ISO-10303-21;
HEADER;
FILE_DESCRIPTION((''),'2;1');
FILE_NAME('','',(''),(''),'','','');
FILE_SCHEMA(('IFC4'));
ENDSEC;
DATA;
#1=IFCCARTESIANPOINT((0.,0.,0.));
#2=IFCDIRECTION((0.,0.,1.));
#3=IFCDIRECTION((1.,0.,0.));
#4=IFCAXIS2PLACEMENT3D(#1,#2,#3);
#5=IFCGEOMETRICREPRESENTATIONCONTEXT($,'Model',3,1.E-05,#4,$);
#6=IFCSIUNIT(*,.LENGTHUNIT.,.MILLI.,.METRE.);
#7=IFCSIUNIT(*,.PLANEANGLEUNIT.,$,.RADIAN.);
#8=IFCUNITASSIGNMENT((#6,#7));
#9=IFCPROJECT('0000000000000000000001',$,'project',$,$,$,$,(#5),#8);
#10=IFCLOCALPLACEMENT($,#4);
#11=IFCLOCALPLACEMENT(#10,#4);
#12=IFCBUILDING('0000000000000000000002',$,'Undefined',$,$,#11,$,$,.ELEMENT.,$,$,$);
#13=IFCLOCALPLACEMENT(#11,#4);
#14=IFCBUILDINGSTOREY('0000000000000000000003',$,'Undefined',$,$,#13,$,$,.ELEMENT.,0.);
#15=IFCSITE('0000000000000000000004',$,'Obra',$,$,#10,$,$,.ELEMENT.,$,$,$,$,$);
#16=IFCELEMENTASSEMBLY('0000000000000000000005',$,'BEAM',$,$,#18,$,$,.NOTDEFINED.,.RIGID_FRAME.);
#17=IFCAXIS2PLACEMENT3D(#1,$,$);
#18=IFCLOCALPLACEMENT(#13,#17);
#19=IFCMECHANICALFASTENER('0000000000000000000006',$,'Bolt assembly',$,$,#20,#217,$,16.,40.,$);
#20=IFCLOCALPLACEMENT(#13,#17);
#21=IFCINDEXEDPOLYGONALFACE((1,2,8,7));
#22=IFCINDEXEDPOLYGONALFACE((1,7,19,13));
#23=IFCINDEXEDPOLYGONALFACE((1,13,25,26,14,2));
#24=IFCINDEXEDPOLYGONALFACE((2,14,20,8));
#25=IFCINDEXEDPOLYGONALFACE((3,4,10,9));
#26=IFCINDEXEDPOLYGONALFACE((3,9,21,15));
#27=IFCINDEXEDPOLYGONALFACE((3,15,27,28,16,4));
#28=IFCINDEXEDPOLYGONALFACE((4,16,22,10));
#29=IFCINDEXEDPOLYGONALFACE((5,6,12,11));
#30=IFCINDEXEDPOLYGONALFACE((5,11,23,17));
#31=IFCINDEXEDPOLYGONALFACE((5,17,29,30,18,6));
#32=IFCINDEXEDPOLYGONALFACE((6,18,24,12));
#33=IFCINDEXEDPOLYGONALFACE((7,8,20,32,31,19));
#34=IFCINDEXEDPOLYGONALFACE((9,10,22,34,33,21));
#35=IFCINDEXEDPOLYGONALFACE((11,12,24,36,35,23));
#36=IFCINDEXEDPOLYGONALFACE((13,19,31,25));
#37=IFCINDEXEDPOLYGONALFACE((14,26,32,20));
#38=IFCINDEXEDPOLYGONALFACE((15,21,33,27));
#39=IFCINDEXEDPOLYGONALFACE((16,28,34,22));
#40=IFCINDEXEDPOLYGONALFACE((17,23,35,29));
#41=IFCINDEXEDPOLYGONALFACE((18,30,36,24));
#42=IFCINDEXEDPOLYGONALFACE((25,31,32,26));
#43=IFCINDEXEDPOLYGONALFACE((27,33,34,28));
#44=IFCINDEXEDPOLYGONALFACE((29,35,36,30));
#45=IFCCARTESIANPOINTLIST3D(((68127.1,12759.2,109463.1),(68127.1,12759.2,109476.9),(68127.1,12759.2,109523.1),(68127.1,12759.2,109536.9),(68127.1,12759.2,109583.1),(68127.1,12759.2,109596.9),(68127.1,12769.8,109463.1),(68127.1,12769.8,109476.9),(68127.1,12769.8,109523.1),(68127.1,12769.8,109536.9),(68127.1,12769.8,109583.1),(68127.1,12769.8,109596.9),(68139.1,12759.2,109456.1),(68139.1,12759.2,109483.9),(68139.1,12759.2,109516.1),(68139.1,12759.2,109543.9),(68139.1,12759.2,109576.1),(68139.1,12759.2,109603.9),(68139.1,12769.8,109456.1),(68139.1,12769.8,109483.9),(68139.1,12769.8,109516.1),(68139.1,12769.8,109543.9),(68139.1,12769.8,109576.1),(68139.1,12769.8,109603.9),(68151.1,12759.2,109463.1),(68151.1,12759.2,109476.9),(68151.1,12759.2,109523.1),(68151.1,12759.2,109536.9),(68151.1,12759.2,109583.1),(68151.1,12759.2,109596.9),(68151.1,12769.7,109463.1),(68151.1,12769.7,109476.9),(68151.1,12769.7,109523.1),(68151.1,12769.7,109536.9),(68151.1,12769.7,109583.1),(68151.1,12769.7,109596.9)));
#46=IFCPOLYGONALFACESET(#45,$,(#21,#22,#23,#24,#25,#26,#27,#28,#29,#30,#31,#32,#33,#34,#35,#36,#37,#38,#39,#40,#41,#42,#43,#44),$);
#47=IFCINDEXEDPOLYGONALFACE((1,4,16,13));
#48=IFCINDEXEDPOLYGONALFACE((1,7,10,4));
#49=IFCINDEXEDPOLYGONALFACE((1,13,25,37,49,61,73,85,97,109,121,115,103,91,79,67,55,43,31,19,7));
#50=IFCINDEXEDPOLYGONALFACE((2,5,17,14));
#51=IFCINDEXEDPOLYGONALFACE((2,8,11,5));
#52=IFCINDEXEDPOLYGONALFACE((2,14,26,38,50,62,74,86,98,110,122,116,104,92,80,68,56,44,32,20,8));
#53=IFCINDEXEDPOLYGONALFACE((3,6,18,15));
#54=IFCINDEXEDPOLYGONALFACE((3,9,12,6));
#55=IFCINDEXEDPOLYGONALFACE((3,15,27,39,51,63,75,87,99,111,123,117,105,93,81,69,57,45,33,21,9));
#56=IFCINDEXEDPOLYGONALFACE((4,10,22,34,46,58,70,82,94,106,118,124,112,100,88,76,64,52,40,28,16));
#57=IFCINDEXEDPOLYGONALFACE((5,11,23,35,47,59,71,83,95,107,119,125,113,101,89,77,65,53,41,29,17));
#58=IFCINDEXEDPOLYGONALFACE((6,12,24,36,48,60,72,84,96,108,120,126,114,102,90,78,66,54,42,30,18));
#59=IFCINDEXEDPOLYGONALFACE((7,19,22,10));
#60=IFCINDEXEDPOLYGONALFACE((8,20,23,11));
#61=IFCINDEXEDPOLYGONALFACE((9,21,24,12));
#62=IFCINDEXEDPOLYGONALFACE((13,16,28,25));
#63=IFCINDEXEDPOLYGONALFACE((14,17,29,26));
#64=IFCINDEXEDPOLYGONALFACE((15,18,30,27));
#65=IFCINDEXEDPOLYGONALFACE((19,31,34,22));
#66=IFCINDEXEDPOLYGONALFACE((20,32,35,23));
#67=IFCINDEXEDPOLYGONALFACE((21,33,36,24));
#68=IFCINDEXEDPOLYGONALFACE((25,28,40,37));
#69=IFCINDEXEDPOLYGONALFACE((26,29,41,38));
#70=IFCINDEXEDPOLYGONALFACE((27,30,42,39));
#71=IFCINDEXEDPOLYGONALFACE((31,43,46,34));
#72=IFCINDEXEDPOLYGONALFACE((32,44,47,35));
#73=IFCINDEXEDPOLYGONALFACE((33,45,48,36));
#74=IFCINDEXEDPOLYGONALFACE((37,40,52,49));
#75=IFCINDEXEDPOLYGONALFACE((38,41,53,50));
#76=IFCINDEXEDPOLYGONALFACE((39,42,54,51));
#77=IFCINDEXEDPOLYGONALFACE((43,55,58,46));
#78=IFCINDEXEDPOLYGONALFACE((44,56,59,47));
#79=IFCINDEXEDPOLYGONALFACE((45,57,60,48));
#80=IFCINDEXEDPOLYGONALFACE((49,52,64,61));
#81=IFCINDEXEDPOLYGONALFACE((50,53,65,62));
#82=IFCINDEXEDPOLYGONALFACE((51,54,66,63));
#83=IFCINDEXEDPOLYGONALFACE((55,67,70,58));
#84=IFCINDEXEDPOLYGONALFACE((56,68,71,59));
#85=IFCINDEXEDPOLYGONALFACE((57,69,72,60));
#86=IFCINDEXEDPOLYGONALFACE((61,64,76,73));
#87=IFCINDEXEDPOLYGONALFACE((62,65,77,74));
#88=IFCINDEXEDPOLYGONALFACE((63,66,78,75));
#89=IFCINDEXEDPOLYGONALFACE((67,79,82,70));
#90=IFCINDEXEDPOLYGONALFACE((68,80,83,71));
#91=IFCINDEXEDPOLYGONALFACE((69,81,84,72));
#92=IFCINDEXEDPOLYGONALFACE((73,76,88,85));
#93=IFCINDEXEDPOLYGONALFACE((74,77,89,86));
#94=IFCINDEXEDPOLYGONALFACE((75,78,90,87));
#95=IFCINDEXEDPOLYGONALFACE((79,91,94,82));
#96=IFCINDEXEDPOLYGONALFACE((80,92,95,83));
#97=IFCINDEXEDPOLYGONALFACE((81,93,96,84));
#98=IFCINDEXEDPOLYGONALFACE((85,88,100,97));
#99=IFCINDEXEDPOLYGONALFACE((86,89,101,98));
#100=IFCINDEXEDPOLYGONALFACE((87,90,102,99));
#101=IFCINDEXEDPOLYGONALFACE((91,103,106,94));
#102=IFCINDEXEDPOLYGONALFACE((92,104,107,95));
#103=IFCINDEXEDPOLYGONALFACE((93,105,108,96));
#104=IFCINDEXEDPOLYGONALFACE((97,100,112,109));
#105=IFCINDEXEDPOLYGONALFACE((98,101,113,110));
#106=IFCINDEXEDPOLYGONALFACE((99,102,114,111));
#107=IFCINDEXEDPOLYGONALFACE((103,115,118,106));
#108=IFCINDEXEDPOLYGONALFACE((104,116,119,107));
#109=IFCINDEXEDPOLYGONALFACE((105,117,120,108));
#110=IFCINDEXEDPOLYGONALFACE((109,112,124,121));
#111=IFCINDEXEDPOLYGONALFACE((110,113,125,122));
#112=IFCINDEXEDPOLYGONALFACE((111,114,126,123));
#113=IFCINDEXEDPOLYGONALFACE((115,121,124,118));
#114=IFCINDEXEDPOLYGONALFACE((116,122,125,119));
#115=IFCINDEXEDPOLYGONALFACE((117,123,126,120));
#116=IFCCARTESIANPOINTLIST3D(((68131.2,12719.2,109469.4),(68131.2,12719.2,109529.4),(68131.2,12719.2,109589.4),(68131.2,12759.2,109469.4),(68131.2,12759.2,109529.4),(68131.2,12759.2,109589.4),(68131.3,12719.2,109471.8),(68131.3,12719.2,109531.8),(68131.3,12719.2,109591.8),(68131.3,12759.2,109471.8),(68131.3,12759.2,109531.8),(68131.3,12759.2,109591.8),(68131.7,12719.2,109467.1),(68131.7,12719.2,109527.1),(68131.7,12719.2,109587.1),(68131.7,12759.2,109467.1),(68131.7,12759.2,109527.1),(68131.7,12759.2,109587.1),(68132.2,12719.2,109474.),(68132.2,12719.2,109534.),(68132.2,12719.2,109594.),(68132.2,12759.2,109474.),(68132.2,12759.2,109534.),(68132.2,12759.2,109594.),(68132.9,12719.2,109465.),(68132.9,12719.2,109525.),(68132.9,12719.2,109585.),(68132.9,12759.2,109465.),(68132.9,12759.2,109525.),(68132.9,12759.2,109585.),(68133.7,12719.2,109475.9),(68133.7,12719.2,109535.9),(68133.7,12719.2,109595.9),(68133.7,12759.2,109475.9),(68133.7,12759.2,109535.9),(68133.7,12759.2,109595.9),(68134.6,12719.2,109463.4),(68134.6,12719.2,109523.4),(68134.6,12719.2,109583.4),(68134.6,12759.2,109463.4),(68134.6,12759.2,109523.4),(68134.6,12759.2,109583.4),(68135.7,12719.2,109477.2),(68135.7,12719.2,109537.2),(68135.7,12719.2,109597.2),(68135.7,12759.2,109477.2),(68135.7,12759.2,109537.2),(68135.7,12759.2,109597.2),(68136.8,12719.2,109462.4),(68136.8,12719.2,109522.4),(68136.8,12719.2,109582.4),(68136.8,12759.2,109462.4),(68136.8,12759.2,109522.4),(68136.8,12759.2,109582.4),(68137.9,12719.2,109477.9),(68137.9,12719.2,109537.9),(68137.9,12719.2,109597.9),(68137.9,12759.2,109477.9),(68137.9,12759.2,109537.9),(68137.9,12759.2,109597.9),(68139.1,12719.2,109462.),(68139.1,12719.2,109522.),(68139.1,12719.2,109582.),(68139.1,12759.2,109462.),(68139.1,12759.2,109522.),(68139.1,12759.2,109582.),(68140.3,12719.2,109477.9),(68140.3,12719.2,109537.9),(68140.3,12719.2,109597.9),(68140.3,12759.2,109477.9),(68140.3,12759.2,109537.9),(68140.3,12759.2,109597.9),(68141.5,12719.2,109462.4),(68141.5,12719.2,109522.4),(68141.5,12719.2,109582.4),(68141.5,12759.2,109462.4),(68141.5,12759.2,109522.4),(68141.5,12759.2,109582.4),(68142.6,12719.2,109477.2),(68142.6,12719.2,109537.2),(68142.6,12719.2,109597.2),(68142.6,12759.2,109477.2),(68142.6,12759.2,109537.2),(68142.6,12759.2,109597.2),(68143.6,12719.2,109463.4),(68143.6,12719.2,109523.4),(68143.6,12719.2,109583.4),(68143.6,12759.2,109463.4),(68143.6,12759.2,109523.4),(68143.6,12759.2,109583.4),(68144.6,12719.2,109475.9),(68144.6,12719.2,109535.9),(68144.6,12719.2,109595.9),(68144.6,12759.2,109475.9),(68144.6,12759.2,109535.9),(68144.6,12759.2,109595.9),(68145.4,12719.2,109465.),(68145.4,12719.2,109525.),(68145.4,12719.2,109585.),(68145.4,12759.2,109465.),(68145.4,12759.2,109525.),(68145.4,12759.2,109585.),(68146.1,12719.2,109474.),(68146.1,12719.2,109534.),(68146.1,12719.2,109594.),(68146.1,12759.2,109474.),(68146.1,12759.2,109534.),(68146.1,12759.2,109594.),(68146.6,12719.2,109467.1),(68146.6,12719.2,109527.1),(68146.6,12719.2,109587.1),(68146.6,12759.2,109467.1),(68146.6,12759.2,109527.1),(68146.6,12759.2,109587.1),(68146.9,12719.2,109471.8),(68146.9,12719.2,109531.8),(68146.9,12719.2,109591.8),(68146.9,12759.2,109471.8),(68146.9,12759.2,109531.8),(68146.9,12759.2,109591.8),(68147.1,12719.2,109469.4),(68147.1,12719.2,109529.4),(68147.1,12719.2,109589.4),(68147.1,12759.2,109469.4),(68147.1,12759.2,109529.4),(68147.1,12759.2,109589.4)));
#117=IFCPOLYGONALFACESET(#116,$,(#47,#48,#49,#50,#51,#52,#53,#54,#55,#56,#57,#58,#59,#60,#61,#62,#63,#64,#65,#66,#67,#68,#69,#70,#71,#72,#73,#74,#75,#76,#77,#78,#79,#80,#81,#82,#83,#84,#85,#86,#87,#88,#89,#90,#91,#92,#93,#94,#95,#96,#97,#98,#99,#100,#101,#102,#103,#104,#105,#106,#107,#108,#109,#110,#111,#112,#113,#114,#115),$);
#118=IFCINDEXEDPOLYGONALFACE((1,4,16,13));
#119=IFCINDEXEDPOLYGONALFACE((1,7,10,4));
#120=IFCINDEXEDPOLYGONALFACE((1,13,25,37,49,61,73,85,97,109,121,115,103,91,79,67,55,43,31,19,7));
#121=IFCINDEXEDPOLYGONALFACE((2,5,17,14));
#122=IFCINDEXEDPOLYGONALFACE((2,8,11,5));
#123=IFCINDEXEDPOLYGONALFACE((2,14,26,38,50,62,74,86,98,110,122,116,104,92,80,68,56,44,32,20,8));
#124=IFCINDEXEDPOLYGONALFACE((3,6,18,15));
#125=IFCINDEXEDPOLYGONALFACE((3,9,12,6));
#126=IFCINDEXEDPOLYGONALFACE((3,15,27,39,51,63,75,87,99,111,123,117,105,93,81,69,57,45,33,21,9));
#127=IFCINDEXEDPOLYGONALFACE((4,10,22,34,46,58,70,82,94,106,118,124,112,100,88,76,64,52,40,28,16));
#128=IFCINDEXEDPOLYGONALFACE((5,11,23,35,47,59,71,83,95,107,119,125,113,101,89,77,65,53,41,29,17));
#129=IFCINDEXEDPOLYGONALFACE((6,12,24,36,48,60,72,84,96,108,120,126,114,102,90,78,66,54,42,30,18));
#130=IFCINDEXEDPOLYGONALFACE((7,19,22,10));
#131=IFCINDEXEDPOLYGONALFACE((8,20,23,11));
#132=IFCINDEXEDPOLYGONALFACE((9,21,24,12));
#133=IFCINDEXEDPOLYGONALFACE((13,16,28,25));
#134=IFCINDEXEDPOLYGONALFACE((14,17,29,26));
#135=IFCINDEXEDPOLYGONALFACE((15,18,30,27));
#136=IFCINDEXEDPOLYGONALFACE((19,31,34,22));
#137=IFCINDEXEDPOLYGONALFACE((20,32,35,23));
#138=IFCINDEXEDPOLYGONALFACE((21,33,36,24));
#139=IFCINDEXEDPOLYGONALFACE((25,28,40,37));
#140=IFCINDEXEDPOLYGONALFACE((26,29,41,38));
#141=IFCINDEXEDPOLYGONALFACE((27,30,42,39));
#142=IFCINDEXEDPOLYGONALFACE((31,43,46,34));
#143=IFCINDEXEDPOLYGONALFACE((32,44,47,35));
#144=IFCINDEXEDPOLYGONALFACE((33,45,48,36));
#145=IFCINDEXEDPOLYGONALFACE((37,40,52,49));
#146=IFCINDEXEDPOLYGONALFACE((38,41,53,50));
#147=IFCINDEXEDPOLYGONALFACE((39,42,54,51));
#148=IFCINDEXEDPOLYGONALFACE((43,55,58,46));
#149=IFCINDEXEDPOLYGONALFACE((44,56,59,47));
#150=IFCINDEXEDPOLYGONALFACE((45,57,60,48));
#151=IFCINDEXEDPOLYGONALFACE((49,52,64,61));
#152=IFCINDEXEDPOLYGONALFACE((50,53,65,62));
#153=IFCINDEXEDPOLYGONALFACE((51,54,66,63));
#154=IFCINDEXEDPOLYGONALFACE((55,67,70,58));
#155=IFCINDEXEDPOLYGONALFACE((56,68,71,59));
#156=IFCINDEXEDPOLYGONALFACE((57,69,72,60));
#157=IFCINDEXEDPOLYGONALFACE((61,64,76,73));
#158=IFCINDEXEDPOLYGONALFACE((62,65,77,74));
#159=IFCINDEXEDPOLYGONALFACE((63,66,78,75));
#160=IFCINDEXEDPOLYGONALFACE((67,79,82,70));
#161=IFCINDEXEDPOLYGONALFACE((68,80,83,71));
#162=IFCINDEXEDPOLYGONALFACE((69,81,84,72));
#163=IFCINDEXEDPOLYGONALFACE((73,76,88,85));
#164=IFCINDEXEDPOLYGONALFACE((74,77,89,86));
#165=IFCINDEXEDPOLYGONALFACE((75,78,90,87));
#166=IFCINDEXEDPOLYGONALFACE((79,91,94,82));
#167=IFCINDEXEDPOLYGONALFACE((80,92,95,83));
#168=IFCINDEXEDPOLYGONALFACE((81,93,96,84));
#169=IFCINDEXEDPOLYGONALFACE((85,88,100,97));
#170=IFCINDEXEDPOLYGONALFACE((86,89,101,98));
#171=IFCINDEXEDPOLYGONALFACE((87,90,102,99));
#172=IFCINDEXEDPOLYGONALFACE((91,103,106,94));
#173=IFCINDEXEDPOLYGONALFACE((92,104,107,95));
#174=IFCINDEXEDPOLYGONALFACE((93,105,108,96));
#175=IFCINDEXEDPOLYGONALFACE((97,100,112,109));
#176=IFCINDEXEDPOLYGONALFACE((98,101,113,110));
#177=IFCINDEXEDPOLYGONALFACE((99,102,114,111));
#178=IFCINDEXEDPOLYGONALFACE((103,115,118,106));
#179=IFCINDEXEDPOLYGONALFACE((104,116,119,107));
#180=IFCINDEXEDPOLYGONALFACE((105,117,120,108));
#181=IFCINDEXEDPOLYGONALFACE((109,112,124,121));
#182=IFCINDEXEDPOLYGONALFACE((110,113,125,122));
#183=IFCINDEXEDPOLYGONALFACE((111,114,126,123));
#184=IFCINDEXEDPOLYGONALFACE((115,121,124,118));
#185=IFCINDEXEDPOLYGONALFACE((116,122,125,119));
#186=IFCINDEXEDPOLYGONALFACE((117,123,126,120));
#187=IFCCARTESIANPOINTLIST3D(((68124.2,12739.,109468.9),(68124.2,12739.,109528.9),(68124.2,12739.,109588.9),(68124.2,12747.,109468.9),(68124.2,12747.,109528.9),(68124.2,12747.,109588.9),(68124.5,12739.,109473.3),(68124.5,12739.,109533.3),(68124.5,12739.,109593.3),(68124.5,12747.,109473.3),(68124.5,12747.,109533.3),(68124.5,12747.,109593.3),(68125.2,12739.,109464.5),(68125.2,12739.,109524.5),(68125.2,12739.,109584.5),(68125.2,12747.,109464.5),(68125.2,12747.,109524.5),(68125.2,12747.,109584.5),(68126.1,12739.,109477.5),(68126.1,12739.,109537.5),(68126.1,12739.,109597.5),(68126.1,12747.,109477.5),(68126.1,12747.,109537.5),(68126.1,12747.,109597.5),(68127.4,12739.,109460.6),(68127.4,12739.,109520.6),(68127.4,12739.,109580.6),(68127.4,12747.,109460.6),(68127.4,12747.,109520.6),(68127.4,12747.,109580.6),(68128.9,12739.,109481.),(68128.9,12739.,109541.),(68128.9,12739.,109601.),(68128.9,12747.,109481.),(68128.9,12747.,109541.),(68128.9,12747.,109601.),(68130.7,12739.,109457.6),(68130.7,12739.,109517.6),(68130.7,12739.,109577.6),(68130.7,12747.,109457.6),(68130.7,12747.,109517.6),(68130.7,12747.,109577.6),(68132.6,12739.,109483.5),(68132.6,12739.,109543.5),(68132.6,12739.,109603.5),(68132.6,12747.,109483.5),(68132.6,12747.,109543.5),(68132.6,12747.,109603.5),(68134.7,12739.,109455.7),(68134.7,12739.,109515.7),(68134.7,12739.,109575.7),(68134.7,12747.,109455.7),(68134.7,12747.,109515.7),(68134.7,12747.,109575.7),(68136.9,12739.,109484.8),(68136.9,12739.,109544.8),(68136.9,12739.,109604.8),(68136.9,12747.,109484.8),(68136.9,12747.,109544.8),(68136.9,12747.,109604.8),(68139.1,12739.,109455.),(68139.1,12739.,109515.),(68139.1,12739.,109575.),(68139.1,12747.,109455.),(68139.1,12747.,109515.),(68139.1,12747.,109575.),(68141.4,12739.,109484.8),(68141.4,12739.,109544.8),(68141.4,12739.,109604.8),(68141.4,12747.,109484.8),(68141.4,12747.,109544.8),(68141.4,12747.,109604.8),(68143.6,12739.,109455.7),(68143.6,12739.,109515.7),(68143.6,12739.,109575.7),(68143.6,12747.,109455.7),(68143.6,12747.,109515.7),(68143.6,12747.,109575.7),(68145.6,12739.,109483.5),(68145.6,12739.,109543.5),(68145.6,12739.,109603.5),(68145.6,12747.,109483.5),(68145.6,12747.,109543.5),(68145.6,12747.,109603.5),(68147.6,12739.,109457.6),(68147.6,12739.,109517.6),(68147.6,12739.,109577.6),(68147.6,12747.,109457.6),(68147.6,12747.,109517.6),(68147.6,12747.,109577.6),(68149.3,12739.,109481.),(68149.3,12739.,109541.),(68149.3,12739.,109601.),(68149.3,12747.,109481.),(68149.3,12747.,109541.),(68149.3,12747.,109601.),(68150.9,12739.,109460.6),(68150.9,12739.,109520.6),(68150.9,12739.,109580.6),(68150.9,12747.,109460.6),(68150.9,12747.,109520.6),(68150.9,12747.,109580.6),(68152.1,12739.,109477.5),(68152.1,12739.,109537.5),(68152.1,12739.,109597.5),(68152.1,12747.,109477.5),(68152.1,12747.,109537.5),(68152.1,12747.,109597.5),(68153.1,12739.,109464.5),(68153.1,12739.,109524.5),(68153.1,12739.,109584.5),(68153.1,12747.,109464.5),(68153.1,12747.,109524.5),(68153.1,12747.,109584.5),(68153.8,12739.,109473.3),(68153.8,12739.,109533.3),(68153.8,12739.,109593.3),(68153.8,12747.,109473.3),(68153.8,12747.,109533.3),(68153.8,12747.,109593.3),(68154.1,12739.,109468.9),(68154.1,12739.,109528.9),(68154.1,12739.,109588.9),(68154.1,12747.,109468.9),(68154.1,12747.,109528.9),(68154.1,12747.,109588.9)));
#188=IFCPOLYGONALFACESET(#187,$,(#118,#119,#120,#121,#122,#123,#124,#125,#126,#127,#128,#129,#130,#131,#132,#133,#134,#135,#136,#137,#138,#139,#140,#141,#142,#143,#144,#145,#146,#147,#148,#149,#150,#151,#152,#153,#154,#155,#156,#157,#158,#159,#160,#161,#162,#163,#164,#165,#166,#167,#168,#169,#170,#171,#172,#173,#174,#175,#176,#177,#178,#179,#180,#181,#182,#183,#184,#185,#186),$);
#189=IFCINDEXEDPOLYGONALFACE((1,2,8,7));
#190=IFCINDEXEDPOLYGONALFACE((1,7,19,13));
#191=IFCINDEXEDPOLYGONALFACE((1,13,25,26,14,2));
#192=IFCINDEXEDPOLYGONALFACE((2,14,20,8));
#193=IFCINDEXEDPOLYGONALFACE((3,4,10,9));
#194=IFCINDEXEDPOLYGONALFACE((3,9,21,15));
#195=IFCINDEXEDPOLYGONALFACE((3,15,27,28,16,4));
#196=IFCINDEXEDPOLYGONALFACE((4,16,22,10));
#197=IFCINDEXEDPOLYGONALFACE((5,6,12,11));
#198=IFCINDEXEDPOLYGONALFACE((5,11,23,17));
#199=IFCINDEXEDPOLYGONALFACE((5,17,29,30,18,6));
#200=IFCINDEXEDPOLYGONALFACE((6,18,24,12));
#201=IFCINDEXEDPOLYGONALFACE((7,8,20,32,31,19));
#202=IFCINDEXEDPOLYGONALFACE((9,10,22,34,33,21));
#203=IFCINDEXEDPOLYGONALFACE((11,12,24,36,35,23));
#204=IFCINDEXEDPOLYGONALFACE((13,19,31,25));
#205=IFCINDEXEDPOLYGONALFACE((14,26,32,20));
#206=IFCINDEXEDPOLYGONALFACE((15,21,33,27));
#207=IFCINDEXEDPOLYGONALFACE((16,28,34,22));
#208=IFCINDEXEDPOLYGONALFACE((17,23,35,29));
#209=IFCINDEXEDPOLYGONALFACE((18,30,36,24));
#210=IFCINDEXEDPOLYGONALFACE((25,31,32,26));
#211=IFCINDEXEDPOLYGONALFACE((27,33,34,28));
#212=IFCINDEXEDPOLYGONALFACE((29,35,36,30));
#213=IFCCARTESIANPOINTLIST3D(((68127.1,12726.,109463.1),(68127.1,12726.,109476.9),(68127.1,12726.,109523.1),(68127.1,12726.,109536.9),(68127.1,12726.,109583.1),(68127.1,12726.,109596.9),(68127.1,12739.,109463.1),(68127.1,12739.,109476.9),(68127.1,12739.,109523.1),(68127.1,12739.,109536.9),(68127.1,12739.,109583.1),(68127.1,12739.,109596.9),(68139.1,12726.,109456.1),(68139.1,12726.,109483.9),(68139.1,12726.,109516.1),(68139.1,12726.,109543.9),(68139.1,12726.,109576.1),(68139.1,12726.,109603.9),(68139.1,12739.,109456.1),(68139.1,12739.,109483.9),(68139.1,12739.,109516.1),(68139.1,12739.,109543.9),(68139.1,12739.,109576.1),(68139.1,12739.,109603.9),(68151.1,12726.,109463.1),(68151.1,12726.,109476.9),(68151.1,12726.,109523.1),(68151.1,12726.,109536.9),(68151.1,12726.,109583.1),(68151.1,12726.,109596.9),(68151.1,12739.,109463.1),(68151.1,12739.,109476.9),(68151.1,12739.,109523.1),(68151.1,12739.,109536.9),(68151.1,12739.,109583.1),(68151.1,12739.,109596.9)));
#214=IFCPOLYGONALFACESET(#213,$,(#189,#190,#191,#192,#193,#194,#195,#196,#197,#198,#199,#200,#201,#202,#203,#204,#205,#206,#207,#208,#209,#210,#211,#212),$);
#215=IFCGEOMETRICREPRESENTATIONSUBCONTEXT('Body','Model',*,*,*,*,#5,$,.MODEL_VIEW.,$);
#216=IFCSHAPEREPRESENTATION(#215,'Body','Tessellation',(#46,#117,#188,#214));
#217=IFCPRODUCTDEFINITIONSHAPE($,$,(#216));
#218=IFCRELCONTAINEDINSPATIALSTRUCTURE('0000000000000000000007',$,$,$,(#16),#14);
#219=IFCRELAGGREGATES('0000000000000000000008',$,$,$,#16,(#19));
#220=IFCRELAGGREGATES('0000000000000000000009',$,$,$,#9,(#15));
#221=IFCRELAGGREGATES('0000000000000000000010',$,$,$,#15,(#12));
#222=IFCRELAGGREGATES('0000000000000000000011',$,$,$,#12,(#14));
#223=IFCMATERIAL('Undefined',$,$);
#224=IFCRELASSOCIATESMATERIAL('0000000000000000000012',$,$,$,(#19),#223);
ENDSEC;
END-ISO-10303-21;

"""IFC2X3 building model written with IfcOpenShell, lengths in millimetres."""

from ifc_helpers import new_model, si_unit, frame, origin_with_axes, origin_2d_with_axis, place, context, subcontext, project, spatial, polyline, circle, outline, extrude, source, transform, mapped, material, element, aggregate, save


model = new_model("IFC2X3")

# Units and contexts
model_context = context("Model", 3, precision=1e-05, world=origin_with_axes())
body_context = subcontext(model_context, "Body", "Model", "MODEL_VIEW")
ifc_project = project(units=[si_unit("LENGTHUNIT", "METRE", prefix="MILLI"), si_unit("PLANEANGLEUNIT", "RADIAN")], contexts=[model_context])

# Site, building, storey
site_placement = place(None, origin_with_axes())
site = spatial("IfcSite", under=ifc_project, at=site_placement, Name="Obra", CompositionType="ELEMENT")
building_placement = place(site_placement, origin_with_axes())
building = spatial("IfcBuilding", under=site, at=building_placement, Name="Undefined", CompositionType="ELEMENT")
storey_placement = place(building_placement, origin_with_axes())
storey = spatial("IfcBuildingStorey", under=building, at=storey_placement, Name="Undefined", CompositionType="ELEMENT", Elevation=0.0)

# Shared definitions
ifc_material_1 = material(Name="Undefined")

# Shared definitions
shared_shape_1 = source(origin_with_axes(), body_context, "Body", "SweptSolid", [
    extrude(outline(polyline([(13.9, 0.0), (6.9, 12.0), (-6.9, 12.0), (-13.9, 0.0), (-6.9, -12.0), (6.9, -12.0), (13.9, 0.0)])), frame((0.0, -19.7, 0.0), z_axis=(0.0, 1.0, 0.0), x_axis=(1.0, 0.0, 0.0)), (0.0, 0.0, 1.0), 10.6),
    extrude(circle(Radius=8.0, at=origin_2d_with_axis()), frame((0.0, -9.1, 0.0), z_axis=(0.0, 1.0, 0.0), x_axis=(1.0, 0.0, 0.0)), (0.0, 0.0, 1.0), 40.0),
    extrude(circle(Radius=15.0, at=origin_2d_with_axis()), frame((0.0, 3.1, 0.0), z_axis=(0.0, 1.0, 0.0), x_axis=(1.0, 0.0, 0.0)), (0.0, 0.0, 1.0), 8.0),
    extrude(outline(polyline([(13.9, 0.0), (6.9, 12.0), (-6.9, 12.0), (-13.9, 0.0), (-6.9, -12.0), (6.9, -12.0), (13.9, 0.0)])), frame((0.0, 11.1, 0.0), z_axis=(0.0, 1.0, 0.0), x_axis=(1.0, 0.0, 0.0)), (0.0, 0.0, 1.0), 13.0),
])

# Element assembly, mechanical fastener
assembly_1_placement = place(storey_placement, origin_with_axes())
assembly_1 = element("IfcElementAssembly", 1, at=assembly_1_placement, inside=storey, Name="BEAM", AssemblyPlace="NOTDEFINED", PredefinedType="RIGID_FRAME")
mechanical_fastener_1_placement = place(assembly_1_placement, frame((68189.1, 12750.1, 109650.0), z_axis=(-1.0, 0.000126, 0.0), x_axis=(0.0, 0.0, -1.0)))
mechanical_fastener_1 = element("IfcMechanicalFastener", 2, at=mechanical_fastener_1_placement, material=ifc_material_1, Name="Bolt assembly", NominalDiameter=16.0, NominalLength=40.0, context=body_context, shape_type="MappedRepresentation", body=[
    mapped(shared_shape_1, transform((60.0, 0.0, 50.0))),
    mapped(shared_shape_1, transform((120.0, 0.0, 50.0))),
    mapped(shared_shape_1, transform((180.0, 0.0, 50.0))),
])
aggregate(assembly_1, [mechanical_fastener_1])

save(model, "model.ifc")
